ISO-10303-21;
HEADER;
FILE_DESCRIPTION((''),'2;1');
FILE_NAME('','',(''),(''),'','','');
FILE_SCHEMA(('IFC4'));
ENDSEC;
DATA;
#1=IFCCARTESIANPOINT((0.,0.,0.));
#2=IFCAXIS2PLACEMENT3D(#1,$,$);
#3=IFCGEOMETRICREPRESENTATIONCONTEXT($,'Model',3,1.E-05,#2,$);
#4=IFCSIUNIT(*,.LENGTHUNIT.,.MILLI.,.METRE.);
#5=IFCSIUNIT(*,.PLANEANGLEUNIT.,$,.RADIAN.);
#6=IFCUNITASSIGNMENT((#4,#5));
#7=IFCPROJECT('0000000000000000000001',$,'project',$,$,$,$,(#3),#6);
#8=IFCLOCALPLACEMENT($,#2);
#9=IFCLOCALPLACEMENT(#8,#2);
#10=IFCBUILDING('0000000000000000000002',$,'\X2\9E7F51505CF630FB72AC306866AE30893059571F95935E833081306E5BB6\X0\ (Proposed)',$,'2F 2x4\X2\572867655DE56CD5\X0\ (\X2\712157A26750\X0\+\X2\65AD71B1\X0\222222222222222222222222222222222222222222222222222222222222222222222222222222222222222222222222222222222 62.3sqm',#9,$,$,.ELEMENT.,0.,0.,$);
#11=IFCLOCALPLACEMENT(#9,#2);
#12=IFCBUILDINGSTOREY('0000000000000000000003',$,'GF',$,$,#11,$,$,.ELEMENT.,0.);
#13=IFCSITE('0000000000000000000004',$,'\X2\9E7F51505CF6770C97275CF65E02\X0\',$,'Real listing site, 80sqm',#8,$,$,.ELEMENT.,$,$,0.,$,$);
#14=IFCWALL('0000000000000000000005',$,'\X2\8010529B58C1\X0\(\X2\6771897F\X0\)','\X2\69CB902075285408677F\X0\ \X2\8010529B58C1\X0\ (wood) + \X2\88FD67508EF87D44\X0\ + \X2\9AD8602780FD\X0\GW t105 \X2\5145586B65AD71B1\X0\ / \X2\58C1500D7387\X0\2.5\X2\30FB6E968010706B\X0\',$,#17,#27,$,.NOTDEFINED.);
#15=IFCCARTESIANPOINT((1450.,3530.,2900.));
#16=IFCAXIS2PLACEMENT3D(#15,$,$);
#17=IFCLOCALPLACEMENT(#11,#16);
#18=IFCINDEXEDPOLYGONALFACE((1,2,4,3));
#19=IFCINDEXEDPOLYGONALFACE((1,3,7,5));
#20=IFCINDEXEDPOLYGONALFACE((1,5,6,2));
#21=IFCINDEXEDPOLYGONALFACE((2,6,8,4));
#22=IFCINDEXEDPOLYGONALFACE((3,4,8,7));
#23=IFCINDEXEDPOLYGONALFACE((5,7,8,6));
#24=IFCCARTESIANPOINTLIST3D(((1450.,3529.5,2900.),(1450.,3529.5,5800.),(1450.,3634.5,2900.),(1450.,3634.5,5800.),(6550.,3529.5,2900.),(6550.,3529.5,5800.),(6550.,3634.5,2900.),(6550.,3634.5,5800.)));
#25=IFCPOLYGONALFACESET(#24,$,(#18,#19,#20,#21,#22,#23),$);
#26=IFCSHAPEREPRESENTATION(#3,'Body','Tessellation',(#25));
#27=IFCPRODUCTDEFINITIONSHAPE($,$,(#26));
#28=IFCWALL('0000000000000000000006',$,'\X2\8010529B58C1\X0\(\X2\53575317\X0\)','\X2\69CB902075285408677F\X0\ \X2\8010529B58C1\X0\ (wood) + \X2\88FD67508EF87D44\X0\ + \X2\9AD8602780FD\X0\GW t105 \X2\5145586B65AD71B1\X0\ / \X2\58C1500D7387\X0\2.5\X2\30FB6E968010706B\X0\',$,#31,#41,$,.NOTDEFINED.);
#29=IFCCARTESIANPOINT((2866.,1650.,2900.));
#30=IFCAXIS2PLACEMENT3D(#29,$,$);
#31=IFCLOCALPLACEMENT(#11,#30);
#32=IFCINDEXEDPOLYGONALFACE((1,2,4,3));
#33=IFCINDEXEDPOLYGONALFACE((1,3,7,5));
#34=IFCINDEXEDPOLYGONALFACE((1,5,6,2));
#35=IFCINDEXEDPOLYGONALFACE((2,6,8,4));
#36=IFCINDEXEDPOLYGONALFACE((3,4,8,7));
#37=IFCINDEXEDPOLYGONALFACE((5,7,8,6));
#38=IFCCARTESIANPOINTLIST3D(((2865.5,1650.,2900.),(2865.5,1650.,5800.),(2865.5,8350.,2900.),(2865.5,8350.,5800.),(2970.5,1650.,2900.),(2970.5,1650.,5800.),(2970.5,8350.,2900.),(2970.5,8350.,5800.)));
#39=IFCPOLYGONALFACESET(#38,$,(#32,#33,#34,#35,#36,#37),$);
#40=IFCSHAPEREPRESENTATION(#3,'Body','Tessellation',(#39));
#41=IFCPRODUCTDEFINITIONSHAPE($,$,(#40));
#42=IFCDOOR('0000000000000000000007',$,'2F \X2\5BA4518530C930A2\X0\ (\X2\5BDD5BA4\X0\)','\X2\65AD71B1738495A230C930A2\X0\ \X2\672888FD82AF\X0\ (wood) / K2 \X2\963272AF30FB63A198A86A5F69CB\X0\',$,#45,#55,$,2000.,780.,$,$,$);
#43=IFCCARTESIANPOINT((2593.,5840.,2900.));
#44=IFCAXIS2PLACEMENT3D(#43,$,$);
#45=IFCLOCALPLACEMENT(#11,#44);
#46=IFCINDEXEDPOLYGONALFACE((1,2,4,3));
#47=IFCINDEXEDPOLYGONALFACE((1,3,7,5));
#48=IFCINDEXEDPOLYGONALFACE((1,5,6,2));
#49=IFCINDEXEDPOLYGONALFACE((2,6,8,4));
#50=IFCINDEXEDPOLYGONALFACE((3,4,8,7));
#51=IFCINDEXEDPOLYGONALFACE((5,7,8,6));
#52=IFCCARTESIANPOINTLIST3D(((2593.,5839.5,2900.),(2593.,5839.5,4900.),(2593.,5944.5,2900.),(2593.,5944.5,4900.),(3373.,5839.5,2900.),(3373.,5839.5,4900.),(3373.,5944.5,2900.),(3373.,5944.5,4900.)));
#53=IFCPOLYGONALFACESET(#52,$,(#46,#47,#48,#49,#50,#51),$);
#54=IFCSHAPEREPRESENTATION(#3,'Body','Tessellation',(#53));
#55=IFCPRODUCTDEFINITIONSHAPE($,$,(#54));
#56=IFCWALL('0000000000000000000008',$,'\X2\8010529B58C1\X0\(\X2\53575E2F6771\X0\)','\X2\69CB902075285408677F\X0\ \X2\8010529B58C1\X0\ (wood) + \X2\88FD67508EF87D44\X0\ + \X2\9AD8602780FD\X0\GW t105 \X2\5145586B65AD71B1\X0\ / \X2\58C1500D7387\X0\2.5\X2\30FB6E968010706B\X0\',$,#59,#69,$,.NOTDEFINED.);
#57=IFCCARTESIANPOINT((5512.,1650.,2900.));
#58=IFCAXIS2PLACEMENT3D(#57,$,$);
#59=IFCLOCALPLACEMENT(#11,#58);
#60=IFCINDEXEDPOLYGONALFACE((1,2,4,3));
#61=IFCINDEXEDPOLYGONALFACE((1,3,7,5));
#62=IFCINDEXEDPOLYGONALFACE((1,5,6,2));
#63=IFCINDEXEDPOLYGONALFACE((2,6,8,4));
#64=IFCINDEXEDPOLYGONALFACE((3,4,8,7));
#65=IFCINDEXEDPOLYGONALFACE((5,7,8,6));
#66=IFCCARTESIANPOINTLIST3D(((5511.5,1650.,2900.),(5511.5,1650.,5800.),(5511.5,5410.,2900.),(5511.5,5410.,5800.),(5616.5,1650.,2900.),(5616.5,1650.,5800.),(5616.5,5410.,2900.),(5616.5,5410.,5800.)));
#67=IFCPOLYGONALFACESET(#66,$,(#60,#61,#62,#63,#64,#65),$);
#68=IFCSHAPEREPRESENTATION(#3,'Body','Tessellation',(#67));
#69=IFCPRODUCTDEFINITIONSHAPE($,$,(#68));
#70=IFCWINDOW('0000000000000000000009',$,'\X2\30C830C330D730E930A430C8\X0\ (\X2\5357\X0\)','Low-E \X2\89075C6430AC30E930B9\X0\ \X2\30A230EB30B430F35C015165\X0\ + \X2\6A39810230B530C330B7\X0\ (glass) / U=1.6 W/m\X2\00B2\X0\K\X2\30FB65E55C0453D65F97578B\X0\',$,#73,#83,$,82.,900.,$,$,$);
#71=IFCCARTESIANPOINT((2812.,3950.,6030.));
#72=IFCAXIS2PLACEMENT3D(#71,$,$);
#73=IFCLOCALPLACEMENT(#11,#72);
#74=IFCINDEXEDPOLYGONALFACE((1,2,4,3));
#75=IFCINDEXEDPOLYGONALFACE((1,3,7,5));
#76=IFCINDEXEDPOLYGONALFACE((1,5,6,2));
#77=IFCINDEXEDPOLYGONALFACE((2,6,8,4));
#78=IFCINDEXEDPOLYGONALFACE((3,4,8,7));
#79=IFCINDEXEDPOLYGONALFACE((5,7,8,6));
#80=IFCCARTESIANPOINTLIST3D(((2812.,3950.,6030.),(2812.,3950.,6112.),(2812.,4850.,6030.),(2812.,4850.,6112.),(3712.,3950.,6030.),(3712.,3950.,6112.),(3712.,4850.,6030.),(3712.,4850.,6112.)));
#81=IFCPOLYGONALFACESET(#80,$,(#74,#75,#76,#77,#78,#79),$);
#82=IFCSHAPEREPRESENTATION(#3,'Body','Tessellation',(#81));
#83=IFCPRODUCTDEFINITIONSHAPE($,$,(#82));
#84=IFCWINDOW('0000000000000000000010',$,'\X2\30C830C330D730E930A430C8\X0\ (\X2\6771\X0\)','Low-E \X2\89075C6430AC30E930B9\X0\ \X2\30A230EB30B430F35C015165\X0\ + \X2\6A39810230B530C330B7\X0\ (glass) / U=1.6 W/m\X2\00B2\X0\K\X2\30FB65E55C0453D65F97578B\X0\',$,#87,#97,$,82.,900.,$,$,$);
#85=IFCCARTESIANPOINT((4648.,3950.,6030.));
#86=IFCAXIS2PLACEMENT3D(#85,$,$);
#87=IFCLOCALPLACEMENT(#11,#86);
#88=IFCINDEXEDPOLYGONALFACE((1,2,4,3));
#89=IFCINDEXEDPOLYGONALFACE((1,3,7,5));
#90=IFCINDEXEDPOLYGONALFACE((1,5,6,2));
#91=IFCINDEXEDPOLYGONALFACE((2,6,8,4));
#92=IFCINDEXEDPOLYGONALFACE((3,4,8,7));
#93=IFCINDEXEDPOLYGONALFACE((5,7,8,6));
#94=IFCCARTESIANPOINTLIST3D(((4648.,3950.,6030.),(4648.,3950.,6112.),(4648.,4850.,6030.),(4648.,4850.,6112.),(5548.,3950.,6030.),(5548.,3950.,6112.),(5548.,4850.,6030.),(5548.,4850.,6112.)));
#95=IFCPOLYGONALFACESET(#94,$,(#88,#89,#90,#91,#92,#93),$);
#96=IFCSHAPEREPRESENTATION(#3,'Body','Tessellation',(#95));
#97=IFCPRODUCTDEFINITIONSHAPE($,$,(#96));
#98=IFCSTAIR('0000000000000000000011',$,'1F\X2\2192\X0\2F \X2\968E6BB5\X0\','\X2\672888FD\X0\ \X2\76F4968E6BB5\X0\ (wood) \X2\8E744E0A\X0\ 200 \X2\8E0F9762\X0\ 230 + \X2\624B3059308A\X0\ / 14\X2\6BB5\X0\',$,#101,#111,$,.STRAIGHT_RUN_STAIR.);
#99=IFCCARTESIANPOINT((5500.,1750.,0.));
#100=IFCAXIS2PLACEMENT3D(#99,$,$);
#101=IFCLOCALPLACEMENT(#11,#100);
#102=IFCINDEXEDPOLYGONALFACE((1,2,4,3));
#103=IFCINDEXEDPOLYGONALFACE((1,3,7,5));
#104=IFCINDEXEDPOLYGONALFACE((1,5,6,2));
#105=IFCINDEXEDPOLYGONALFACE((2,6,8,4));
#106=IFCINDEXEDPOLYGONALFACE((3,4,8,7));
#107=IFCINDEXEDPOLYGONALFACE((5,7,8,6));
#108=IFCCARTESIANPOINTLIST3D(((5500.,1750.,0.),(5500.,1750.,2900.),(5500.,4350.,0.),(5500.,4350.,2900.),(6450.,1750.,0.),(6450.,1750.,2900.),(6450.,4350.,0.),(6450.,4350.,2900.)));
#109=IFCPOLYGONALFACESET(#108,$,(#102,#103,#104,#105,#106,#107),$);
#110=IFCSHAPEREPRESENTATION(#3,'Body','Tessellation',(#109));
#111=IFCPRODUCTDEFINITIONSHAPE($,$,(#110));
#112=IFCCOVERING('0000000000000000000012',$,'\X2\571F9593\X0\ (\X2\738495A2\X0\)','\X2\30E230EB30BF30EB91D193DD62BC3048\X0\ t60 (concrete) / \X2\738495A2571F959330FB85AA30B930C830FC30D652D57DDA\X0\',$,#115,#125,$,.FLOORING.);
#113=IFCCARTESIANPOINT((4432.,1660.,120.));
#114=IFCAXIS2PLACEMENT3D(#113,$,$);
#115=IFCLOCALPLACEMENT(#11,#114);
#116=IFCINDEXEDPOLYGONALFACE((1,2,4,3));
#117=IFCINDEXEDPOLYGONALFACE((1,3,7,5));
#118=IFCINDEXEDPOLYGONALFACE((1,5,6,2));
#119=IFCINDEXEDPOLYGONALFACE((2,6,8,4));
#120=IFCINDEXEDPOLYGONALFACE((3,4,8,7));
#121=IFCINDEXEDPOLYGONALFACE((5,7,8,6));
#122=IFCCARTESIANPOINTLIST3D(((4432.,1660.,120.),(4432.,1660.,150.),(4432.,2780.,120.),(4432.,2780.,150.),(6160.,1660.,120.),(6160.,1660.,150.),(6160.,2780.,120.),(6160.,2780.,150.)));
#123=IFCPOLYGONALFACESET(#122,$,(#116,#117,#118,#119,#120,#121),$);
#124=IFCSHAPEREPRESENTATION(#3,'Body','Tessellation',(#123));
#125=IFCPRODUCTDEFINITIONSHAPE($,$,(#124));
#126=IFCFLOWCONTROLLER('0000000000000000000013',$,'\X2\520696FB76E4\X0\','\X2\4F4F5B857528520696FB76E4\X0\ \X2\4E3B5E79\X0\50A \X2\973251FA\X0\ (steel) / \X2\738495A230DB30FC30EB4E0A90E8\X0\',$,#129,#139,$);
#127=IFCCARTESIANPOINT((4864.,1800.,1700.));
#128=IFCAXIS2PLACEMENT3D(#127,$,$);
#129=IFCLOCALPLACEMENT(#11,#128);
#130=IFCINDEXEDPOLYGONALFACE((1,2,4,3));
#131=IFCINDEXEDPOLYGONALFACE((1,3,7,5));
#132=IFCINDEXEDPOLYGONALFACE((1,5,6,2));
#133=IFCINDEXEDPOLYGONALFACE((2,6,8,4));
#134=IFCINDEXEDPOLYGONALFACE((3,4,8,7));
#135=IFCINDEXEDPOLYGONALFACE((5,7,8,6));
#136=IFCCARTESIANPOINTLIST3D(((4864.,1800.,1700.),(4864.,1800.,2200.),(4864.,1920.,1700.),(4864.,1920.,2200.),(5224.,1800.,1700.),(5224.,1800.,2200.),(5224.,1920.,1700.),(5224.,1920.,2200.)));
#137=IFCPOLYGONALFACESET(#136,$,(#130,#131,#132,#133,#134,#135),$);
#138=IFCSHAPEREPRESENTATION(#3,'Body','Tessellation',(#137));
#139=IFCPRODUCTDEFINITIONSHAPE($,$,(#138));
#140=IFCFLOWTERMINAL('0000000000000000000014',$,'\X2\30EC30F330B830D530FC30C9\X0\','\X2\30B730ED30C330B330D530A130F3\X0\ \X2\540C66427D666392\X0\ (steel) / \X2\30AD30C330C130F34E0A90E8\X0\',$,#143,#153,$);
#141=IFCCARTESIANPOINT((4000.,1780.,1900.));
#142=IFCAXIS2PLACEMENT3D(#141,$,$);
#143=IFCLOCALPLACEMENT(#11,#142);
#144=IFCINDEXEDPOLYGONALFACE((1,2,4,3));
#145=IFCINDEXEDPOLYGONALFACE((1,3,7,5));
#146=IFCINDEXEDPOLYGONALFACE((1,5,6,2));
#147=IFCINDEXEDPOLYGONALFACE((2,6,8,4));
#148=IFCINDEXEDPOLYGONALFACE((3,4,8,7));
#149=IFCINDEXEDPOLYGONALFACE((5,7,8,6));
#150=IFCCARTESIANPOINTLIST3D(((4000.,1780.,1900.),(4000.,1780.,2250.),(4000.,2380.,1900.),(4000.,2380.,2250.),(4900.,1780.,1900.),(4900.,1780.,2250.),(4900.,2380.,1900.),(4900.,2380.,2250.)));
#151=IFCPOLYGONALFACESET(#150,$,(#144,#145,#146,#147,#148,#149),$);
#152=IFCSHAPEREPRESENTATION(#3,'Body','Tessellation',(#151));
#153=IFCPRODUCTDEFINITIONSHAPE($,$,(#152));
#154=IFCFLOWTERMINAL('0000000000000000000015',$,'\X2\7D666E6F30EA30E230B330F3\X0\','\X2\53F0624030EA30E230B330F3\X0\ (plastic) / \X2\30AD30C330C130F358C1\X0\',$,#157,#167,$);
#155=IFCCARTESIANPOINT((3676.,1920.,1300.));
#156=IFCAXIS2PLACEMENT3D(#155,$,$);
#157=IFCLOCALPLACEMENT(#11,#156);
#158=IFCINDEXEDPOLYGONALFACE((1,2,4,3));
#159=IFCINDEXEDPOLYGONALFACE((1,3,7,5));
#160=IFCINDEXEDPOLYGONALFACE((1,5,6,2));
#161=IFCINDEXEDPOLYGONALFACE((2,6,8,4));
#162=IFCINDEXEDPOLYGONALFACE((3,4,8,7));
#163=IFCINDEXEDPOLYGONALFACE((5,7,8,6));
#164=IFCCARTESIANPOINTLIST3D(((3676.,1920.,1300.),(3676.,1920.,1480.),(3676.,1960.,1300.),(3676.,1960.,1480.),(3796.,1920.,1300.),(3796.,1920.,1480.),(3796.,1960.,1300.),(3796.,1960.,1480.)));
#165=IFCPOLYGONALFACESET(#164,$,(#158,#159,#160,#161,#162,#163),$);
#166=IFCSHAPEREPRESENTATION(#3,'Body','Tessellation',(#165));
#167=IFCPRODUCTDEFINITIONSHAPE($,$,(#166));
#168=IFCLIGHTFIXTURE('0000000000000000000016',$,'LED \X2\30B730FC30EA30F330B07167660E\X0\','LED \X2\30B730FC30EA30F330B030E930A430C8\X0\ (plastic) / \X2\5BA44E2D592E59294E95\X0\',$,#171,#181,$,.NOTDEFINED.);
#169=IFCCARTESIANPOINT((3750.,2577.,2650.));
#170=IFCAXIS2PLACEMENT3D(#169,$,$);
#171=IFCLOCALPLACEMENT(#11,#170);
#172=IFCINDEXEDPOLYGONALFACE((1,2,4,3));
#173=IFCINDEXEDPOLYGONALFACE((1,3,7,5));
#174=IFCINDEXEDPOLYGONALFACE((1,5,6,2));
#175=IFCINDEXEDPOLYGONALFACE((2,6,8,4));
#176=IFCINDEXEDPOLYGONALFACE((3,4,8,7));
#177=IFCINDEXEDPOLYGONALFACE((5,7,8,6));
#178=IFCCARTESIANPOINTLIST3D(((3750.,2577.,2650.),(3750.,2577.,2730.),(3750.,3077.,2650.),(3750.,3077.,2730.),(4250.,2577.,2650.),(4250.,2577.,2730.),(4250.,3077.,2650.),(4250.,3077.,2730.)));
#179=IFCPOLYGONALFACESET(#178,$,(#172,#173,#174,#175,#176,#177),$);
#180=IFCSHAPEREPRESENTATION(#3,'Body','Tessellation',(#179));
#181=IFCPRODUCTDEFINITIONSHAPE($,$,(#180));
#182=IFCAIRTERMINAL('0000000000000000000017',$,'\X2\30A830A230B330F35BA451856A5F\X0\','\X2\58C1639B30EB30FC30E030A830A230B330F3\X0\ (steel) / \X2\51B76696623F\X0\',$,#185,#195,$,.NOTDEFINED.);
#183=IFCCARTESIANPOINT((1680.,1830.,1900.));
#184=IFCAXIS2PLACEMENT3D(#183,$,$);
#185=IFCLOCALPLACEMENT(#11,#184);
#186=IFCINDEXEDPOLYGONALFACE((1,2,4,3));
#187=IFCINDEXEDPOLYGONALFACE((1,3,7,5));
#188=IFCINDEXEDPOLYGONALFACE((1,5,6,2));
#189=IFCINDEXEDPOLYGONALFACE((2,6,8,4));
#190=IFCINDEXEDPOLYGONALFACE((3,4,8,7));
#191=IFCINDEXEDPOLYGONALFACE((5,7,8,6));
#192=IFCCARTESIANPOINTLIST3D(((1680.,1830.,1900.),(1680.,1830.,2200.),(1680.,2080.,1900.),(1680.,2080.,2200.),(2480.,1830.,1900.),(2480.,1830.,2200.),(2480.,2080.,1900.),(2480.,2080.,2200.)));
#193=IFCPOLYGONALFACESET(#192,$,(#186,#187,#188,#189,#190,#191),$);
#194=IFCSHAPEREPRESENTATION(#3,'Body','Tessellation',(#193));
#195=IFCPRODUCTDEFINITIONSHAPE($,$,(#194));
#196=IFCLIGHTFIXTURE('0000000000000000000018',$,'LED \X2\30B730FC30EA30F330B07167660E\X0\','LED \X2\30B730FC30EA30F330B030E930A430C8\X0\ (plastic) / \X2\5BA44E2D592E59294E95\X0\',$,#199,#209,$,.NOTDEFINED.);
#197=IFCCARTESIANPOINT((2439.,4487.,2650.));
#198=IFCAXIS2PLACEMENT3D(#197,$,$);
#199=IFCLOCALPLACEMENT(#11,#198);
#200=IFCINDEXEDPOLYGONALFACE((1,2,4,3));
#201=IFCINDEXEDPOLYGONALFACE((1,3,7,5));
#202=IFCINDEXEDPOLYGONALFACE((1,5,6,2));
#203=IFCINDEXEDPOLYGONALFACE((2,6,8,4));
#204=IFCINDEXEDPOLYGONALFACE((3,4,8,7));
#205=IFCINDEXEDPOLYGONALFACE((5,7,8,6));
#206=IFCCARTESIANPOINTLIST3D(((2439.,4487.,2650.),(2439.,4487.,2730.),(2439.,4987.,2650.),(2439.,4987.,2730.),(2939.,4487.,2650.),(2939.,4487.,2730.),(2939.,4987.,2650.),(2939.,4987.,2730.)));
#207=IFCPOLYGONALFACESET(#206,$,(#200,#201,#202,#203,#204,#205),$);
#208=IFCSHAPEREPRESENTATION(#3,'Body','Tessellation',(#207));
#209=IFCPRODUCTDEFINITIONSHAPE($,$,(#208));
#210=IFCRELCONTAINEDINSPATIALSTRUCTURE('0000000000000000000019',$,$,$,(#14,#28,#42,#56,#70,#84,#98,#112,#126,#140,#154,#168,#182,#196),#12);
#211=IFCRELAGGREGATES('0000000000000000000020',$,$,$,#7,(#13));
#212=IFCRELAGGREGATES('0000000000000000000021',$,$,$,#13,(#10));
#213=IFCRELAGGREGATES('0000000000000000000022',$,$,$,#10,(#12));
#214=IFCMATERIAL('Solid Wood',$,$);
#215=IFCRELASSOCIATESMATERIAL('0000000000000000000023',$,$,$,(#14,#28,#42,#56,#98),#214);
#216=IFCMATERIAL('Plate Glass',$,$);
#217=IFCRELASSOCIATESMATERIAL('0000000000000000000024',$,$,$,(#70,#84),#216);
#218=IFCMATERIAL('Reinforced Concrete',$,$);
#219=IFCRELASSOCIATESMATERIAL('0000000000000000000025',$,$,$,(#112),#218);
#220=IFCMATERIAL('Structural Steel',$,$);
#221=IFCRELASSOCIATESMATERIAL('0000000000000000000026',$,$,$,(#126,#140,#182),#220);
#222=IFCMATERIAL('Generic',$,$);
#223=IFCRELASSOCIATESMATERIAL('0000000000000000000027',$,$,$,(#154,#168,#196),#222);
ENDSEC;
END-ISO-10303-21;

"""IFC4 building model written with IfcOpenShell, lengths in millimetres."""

from ifc_helpers import new_model, si_unit, frame, frame_2d, origin, place, context, project, spatial, rectangle, extrude, material, element, fill, save


model = new_model("IFC4")

# Units and contexts
model_context = context("Model", 3, precision=1e-05, world=origin())
ifc_project = project(units=[si_unit("LENGTHUNIT", "METRE", prefix="MILLI"), si_unit("PLANEANGLEUNIT", "RADIAN")], contexts=[model_context])

# Site, building, storey
site_placement = place(None, origin())
site = spatial("IfcSite", under=ifc_project, at=site_placement, Name="鹿児島県霧島市", ObjectType="Real listing site, 80sqm", CompositionType="ELEMENT", RefElevation=0.0)
building_placement = place(site_placement, origin())
building = spatial("IfcBuilding", under=site, at=building_placement, Name="鹿児島・犬と暮らす土間広めの家 (Proposed)", ObjectType="2F 2x4在来工法 (無垢材+断熱222222222222222222222222222222222222222222222222222222222222222222222222222222222222222222222222222222222 62.3sqm", CompositionType="ELEMENT", ElevationOfRefHeight=0.0, ElevationOfTerrain=0.0)
storey_placement = place(building_placement, origin())
storey = spatial("IfcBuildingStorey", under=building, at=storey_placement, Name="GF", CompositionType="ELEMENT", Elevation=0.0)

# Shared definitions
ifc_material_1 = material(Name="Solid Wood")

# Wall
wall_1_placement = place(storey_placement, frame((1450.0, 3530.0, 2900.0)))
element("IfcWall", 1, at=wall_1_placement, inside=storey, material=ifc_material_1, Name="耐力壁(東西)", Description="構造用合板 耐力壁 (wood) + 製材軸組 + 高性能GW t105 充填断熱 / 壁倍率2.5・準耐火", PredefinedType="NOTDEFINED", context=model_context, shape_type="SweptSolid", body=[
    extrude(rectangle(XDim=5100.0, YDim=105.0, at=frame_2d((2550.0, 52.0))), frame((1450.0, 3530.0, 2900.0)), (0.0, 0.0, 1.0), 2900.0),
])

# Wall, opening, door
wall_2_placement = place(storey_placement, frame((2866.0, 1650.0, 2900.0)))
wall_2 = element("IfcWall", 2, at=wall_2_placement, inside=storey, material=ifc_material_1, Name="耐力壁(南北)", Description="構造用合板 耐力壁 (wood) + 製材軸組 + 高性能GW t105 充填断熱 / 壁倍率2.5・準耐火", PredefinedType="NOTDEFINED", context=model_context, shape_type="SweptSolid", body=[
    extrude(rectangle(XDim=105.0, YDim=6700.0, at=frame_2d((52.0, 3350.0))), frame((2866.0, 1650.0, 2900.0)), (0.0, 0.0, 1.0), 2900.0),
])
opening_placement = place(storey_placement, frame((2593.0, 5840.0, 2900.0)))
opening = element("IfcOpeningElement", 3, at=opening_placement, cuts=wall_2, PredefinedType="NOTDEFINED", context=model_context, shape_type="SweptSolid", body=[
    extrude(rectangle(XDim=780.0, YDim=105.0, at=frame_2d((390.0, 52.0))), frame((2593.0, 5840.0, 2900.0)), (0.0, 0.0, 1.0), 2000.0),
])
door_placement = place(storey_placement, frame((2593.0, 5840.0, 2900.0)))
door = element("IfcDoor", 4, at=door_placement, inside=storey, material=ifc_material_1, Name="2F 室内ドア (寝室)", Description="断熱玄関ドア 木製芯 (wood) / K2 防犯・採風機構", OverallHeight=2000.0, OverallWidth=780.0, context=model_context, shape_type="SweptSolid", body=[
    extrude(rectangle(XDim=780.0, YDim=105.0, at=frame_2d((390.0, 52.0))), frame((2593.0, 5840.0, 2900.0)), (0.0, 0.0, 1.0), 2000.0),
])
fill(opening, door)

# Wall
wall_3_placement = place(storey_placement, frame((5512.0, 1650.0, 2900.0)))
element("IfcWall", 5, at=wall_3_placement, inside=storey, material=ifc_material_1, Name="耐力壁(南帯東)", Description="構造用合板 耐力壁 (wood) + 製材軸組 + 高性能GW t105 充填断熱 / 壁倍率2.5・準耐火", PredefinedType="NOTDEFINED", context=model_context, shape_type="SweptSolid", body=[
    extrude(rectangle(XDim=105.0, YDim=3760.0, at=frame_2d((52.0, 1880.0))), frame((5512.0, 1650.0, 2900.0)), (0.0, 0.0, 1.0), 2900.0),
])

# Windows
ifc_material_2 = material(Name="Plate Glass")
window_1_placement = place(storey_placement, frame((2812.0, 3950.0, 6030.0)))
element("IfcWindow", 6, at=window_1_placement, inside=storey, material=ifc_material_2, Name="トップライト (南)", Description="Low-E 複層ガラス アルゴン封入 + 樹脂サッシ (glass) / U=1.6 W/m²K・日射取得型", OverallHeight=82.0, OverallWidth=900.0, context=model_context, shape_type="SweptSolid", body=[
    extrude(rectangle(XDim=900.0, YDim=900.0, at=frame_2d((450.0, 450.0))), frame((2812.0, 3950.0, 6030.0)), (0.0, 0.0, 1.0), 82.0),
])
window_2_placement = place(storey_placement, frame((4648.0, 3950.0, 6030.0)))
element("IfcWindow", 7, at=window_2_placement, inside=storey, material=ifc_material_2, Name="トップライト (東)", Description="Low-E 複層ガラス アルゴン封入 + 樹脂サッシ (glass) / U=1.6 W/m²K・日射取得型", OverallHeight=82.0, OverallWidth=900.0, context=model_context, shape_type="SweptSolid", body=[
    extrude(rectangle(XDim=900.0, YDim=900.0, at=frame_2d((450.0, 450.0))), frame((4648.0, 3950.0, 6030.0)), (0.0, 0.0, 1.0), 82.0),
])

# Stair
stair_placement = place(storey_placement, frame((5500.0, 1750.0, 0.0)))
element("IfcStair", 8, at=stair_placement, inside=storey, material=ifc_material_1, Name="1F→2F 階段", Description="木製 直階段 (wood) 蹴上 200 踏面 230 + 手すり / 14段", PredefinedType="STRAIGHT_RUN_STAIR", context=model_context, shape_type="SweptSolid", body=[
    extrude(rectangle(XDim=950.0, YDim=2600.0, at=frame_2d((475.0, 1300.0))), frame((5500.0, 1750.0, 0.0)), (0.0, 0.0, 1.0), 2900.0),
])

# Covering
ifc_material_3 = material(Name="Reinforced Concrete")
covering_placement = place(storey_placement, frame((4432.0, 1660.0, 120.0)))
element("IfcCovering", 9, at=covering_placement, inside=storey, material=ifc_material_3, Name="土間 (玄関)", Description="モルタル金鏝押え t60 (concrete) / 玄関土間・薪ストーブ動線", PredefinedType="FLOORING", context=model_context, shape_type="SweptSolid", body=[
    extrude(rectangle(XDim=1728.0, YDim=1120.0, at=frame_2d((864.0, 560.0))), frame((4432.0, 1660.0, 120.0)), (0.0, 0.0, 1.0), 30.0),
])

# Shared definitions
ifc_material_4 = material(Name="Structural Steel")

# Flow controller
flow_controller_placement = place(storey_placement, frame((4864.0, 1800.0, 1700.0)))
element("IfcFlowController", 10, at=flow_controller_placement, inside=storey, material=ifc_material_4, Name="分電盤", Description="住宅用分電盤 主幹50A 露出 (steel) / 玄関ホール上部", context=model_context, shape_type="SweptSolid", body=[
    extrude(rectangle(XDim=360.0, YDim=120.0, at=frame_2d((180.0, 60.0))), frame((4864.0, 1800.0, 1700.0)), (0.0, 0.0, 1.0), 500.0),
])

# Flow terminals
flow_terminal_1_placement = place(storey_placement, frame((4000.0, 1780.0, 1900.0)))
element("IfcFlowTerminal", 11, at=flow_terminal_1_placement, inside=storey, material=ifc_material_4, Name="レンジフード", Description="シロッコファン 同時給排 (steel) / キッチン上部", context=model_context, shape_type="SweptSolid", body=[
    extrude(rectangle(XDim=900.0, YDim=600.0, at=frame_2d((450.0, 300.0))), frame((4000.0, 1780.0, 1900.0)), (0.0, 0.0, 1.0), 350.0),
])
ifc_material_5 = material(Name="Generic")
flow_terminal_2_placement = place(storey_placement, frame((3676.0, 1920.0, 1300.0)))
element("IfcFlowTerminal", 12, at=flow_terminal_2_placement, inside=storey, material=ifc_material_5, Name="給湯リモコン", Description="台所リモコン (plastic) / キッチン壁", context=model_context, shape_type="SweptSolid", body=[
    extrude(rectangle(XDim=120.0, YDim=40.0, at=frame_2d((60.0, 20.0))), frame((3676.0, 1920.0, 1300.0)), (0.0, 0.0, 1.0), 180.0),
])

# Light fixture
light_fixture_1_placement = place(storey_placement, frame((3750.0, 2577.0, 2650.0)))
element("IfcLightFixture", 13, at=light_fixture_1_placement, inside=storey, material=ifc_material_5, Name="LED シーリング照明", Description="LED シーリングライト (plastic) / 室中央天井", PredefinedType="NOTDEFINED", context=model_context, shape_type="SweptSolid", body=[
    extrude(rectangle(XDim=500.0, YDim=500.0, at=frame_2d((250.0, 250.0))), frame((3750.0, 2577.0, 2650.0)), (0.0, 0.0, 1.0), 80.0),
])

# Air terminal
air_terminal_1_placement = place(storey_placement, frame((1680.0, 1830.0, 1900.0)))
element("IfcAirTerminal", 14, at=air_terminal_1_placement, inside=storey, material=ifc_material_4, Name="エアコン室内機", Description="壁掛ルームエアコン (steel) / 冷暖房", PredefinedType="NOTDEFINED", context=model_context, shape_type="SweptSolid", body=[
    extrude(rectangle(XDim=800.0, YDim=250.0, at=frame_2d((400.0, 125.0))), frame((1680.0, 1830.0, 1900.0)), (0.0, 0.0, 1.0), 300.0),
])

# Light fixture
light_fixture_2_placement = place(storey_placement, frame((2439.0, 4487.0, 2650.0)))
element("IfcLightFixture", 15, at=light_fixture_2_placement, inside=storey, material=ifc_material_5, Name="LED シーリング照明", Description="LED シーリングライト (plastic) / 室中央天井", PredefinedType="NOTDEFINED", context=model_context, shape_type="SweptSolid", body=[
    extrude(rectangle(XDim=500.0, YDim=500.0, at=frame_2d((250.0, 250.0))), frame((2439.0, 4487.0, 2650.0)), (0.0, 0.0, 1.0), 80.0),
])

save(model, "model.ifc")
